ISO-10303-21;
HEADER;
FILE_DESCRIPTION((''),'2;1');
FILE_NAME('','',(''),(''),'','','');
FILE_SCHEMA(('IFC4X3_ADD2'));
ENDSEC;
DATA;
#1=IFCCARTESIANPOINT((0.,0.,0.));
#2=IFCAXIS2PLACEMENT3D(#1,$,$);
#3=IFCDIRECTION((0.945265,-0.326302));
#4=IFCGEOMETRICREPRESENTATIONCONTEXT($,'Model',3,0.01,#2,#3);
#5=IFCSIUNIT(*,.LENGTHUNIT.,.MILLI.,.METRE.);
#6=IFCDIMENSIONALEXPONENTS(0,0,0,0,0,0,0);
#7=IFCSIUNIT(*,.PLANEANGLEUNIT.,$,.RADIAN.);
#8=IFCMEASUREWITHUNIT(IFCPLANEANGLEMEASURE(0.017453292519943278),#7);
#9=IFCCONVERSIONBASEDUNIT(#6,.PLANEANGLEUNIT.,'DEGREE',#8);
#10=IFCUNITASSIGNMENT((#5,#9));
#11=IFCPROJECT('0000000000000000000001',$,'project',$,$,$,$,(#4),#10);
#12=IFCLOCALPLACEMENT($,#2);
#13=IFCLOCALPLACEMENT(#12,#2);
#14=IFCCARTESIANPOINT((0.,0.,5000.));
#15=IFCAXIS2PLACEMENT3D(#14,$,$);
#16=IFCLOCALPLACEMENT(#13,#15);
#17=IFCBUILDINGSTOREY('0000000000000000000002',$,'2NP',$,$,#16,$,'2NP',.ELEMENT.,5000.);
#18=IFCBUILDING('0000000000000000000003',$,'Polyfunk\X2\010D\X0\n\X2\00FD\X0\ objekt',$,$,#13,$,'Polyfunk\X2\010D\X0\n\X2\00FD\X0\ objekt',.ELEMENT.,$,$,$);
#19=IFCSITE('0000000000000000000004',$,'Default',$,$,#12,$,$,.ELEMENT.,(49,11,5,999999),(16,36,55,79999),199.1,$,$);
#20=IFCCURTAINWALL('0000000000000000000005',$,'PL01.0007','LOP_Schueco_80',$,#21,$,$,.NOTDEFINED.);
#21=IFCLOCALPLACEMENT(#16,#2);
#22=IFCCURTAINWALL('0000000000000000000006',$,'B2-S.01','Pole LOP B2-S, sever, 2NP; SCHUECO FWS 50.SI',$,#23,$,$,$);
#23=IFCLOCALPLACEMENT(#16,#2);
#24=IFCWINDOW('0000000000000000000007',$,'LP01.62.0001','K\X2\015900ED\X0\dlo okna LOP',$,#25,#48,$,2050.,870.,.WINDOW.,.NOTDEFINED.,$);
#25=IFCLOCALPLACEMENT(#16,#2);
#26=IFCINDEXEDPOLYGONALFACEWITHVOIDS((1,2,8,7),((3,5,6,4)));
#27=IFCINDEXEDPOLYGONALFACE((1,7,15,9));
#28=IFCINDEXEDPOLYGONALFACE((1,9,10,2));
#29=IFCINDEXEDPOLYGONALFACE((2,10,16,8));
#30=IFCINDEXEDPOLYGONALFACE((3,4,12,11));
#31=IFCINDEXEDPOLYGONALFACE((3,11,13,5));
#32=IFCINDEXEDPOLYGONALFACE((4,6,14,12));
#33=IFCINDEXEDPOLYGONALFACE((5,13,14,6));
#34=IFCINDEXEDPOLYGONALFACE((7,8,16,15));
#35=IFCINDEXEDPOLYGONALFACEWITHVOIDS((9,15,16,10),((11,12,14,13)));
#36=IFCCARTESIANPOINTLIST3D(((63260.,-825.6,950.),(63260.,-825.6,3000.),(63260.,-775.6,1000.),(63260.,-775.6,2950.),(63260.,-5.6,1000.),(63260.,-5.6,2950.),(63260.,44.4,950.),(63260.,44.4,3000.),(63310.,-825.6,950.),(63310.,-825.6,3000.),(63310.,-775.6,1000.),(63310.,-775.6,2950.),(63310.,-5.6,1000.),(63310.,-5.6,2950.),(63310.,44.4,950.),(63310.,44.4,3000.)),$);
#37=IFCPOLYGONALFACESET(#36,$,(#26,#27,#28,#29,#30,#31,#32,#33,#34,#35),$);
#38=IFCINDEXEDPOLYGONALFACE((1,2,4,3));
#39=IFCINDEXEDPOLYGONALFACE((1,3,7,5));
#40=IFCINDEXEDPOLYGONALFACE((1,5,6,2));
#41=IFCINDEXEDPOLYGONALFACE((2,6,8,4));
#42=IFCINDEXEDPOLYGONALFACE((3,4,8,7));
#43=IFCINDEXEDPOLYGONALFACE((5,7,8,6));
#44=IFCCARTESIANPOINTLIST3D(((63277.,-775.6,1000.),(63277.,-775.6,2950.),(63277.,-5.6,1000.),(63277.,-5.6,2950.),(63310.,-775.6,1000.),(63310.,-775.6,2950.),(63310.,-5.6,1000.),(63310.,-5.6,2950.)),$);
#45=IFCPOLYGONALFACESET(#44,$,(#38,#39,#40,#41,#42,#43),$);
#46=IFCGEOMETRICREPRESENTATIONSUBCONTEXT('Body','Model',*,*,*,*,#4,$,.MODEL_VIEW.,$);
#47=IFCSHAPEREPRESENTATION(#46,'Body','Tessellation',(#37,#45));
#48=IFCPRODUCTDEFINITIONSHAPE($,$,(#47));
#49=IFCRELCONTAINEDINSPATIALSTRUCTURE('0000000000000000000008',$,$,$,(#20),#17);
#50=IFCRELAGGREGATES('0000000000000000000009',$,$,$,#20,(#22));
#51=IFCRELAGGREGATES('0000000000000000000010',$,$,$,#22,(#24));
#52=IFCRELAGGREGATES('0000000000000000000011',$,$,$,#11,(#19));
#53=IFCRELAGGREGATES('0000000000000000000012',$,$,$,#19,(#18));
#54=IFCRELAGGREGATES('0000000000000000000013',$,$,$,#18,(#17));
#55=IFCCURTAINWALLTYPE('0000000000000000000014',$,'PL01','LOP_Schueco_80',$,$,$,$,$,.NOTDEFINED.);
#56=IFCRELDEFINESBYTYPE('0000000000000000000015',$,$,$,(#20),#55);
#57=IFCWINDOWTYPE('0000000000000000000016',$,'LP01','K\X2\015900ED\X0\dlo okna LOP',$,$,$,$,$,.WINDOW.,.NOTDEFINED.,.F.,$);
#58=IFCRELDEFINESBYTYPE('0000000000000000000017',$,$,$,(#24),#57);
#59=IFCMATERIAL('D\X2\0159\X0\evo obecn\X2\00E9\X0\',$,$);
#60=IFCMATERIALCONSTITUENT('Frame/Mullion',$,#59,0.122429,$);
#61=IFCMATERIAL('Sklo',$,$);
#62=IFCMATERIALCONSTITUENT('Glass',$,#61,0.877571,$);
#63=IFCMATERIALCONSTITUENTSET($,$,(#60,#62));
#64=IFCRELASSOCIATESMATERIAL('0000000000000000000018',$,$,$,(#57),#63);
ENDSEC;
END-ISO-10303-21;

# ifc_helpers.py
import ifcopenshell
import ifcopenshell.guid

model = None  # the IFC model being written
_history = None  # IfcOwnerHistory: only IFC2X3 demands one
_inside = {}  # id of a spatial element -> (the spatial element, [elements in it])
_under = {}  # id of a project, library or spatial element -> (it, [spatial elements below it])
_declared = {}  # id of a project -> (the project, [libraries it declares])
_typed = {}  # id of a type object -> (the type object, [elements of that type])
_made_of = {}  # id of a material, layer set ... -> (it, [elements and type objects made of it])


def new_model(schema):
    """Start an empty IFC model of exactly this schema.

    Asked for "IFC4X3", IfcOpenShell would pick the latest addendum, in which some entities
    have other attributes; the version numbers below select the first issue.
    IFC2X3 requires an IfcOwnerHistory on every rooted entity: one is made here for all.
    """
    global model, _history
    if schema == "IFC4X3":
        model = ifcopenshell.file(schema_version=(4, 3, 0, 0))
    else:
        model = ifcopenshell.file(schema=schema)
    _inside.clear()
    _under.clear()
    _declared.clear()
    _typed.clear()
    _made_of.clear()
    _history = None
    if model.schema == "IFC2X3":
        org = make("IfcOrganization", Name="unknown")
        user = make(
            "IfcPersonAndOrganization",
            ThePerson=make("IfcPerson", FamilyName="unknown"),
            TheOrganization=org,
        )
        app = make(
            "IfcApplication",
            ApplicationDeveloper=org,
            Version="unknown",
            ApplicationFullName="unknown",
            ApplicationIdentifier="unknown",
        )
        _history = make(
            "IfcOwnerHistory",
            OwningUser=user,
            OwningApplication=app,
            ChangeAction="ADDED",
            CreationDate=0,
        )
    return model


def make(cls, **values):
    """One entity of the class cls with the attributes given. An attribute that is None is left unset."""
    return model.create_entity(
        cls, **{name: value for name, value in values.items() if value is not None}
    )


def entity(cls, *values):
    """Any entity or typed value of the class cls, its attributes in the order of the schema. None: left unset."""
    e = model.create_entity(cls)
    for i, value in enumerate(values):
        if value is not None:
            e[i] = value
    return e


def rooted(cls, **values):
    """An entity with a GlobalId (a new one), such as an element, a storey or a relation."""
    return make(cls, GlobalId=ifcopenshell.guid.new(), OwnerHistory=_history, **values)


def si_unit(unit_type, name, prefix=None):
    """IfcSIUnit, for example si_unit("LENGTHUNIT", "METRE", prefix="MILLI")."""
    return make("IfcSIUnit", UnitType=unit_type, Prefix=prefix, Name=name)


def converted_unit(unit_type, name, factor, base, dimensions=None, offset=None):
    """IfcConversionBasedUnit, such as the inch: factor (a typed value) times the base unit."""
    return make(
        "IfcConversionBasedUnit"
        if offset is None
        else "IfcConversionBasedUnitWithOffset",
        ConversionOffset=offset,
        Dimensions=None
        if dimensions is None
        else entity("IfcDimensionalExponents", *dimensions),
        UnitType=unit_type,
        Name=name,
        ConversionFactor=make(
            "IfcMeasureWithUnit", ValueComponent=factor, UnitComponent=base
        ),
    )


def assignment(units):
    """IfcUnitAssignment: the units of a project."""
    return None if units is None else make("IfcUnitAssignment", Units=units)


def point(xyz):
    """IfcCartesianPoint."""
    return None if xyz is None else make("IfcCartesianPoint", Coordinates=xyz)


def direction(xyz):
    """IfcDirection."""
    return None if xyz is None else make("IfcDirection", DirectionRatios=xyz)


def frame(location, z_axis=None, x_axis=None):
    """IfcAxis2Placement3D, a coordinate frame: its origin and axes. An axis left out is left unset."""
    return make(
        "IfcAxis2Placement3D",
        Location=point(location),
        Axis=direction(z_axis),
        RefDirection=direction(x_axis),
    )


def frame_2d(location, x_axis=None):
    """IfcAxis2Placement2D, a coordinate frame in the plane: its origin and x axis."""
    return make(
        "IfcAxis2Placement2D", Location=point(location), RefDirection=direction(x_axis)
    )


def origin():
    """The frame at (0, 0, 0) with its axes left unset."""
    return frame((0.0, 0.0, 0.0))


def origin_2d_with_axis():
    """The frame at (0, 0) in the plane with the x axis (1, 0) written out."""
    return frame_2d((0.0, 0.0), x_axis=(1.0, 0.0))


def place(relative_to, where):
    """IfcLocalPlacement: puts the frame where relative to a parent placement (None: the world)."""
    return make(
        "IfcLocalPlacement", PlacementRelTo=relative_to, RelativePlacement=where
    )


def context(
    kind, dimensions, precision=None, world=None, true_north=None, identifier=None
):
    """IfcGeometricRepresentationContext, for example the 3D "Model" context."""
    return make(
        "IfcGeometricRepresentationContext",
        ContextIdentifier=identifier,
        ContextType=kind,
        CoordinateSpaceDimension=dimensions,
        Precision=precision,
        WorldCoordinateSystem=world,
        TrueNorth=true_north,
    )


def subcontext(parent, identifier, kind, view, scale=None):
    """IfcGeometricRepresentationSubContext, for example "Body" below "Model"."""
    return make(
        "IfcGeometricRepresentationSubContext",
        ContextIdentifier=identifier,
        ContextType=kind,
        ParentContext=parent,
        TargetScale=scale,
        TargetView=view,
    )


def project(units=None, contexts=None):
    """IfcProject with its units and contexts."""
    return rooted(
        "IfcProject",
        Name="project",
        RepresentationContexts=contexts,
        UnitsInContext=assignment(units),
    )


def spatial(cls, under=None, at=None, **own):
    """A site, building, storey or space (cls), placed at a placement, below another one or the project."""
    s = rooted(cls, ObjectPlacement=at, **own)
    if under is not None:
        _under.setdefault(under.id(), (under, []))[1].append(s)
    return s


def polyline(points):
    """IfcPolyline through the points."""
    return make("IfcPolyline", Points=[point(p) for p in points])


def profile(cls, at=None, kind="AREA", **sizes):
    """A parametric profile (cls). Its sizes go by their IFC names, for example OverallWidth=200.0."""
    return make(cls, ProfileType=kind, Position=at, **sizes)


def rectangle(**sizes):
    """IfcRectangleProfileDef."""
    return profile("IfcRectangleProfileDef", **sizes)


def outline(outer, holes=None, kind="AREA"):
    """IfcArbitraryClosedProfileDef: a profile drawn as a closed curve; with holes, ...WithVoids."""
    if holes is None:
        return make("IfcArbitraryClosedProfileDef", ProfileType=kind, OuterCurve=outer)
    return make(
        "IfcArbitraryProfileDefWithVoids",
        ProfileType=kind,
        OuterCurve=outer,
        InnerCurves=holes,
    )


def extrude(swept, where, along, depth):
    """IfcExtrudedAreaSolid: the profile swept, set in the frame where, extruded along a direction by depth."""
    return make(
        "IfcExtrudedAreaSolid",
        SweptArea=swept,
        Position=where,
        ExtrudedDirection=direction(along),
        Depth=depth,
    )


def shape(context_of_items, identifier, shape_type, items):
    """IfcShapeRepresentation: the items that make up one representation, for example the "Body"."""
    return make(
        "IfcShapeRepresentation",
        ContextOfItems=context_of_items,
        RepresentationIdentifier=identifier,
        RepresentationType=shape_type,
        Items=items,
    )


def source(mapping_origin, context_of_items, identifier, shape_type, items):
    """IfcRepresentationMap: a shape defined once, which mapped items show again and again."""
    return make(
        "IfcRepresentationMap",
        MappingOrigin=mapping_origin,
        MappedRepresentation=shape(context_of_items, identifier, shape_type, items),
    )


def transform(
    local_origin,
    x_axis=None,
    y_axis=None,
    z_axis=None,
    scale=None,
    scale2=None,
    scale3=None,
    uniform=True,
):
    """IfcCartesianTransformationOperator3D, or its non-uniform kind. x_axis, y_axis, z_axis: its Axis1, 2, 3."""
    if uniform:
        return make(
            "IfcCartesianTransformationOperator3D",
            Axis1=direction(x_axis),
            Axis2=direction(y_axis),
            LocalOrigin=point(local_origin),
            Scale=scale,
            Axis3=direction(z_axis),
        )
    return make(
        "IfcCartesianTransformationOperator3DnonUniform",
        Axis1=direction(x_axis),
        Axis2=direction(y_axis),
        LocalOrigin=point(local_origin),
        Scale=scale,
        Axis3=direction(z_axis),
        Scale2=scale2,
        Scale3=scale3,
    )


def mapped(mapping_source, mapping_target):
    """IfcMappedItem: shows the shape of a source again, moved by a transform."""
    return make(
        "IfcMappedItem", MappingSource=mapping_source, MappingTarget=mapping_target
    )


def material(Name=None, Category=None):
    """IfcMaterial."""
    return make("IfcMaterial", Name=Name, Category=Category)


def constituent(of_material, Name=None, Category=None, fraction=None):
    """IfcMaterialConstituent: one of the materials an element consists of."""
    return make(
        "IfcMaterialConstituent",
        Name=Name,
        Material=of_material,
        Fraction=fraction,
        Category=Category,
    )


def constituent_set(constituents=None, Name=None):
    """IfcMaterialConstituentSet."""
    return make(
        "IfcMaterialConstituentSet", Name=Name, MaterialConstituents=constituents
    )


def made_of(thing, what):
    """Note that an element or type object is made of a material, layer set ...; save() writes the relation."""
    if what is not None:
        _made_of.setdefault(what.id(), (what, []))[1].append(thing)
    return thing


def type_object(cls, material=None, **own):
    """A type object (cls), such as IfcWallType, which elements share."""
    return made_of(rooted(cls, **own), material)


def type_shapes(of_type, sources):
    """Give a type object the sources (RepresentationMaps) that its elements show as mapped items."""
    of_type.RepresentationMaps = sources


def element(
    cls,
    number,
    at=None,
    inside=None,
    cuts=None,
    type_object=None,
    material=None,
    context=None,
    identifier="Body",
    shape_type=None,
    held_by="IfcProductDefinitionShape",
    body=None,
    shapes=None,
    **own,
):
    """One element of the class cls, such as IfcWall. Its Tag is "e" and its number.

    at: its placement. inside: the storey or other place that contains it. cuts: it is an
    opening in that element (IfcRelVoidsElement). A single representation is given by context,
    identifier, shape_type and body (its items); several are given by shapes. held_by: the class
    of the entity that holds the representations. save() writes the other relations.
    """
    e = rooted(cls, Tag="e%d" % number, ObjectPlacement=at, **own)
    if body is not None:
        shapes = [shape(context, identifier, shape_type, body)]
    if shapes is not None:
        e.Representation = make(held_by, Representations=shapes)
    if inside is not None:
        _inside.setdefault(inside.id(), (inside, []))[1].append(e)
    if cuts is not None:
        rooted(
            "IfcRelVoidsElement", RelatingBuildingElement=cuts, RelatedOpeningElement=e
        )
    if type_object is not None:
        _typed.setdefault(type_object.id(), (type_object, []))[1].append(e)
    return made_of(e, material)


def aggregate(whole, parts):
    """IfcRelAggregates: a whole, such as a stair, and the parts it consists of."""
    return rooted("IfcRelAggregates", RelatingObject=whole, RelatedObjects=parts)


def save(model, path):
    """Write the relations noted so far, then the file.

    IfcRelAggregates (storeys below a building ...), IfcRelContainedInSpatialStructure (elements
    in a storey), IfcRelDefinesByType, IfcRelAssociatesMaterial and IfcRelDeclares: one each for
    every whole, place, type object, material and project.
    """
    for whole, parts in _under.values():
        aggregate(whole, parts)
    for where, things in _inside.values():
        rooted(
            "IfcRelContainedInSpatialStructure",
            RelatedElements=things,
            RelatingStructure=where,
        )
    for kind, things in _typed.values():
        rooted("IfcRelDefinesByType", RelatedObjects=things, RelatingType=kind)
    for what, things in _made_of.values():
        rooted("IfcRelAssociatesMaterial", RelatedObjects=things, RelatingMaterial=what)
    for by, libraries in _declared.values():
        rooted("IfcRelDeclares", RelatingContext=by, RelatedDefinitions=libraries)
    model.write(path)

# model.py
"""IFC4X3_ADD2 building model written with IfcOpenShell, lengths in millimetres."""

from ifc_helpers import new_model, entity, si_unit, converted_unit, direction, frame, origin, origin_2d_with_axis, place, context, subcontext, project, spatial, polyline, rectangle, outline, extrude, source, transform, mapped, material, constituent, constituent_set, type_object, type_shapes, element, aggregate, save


model = new_model("IFC4X3_ADD2")

# Units and contexts
model_context = context("Model", 3, precision=0.01, world=origin(), true_north=direction((0.945265, -0.326302)))
body_context = subcontext(model_context, "Body", "Model", "MODEL_VIEW")
ifc_project = project(units=[si_unit("LENGTHUNIT", "METRE", prefix="MILLI"), converted_unit("PLANEANGLEUNIT", "DEGREE", entity("IfcPlaneAngleMeasure", 0.017453292519943278), si_unit("PLANEANGLEUNIT", "RADIAN"), dimensions=[0, 0, 0, 0, 0, 0, 0])], contexts=[model_context])

# Site, building, storey
site_placement = place(None, origin())
site = spatial("IfcSite", under=ifc_project, at=site_placement, Name="Default", CompositionType="ELEMENT", RefLatitude=(49, 11, 5, 999999), RefLongitude=(16, 36, 55, 79999), RefElevation=199.1)
building_placement = place(site_placement, origin())
building = spatial("IfcBuilding", under=site, at=building_placement, Name="Polyfunkčný objekt", LongName="Polyfunkčný objekt", CompositionType="ELEMENT")
storey_placement = place(building_placement, frame((0.0, 0.0, 5000.0)))
storey = spatial("IfcBuildingStorey", under=building, at=storey_placement, Name="2NP", LongName="2NP", CompositionType="ELEMENT", Elevation=5000.0)

# Curtain walls, window
curtain_wall_type = type_object("IfcCurtainWallType", Name="PL01", Description="LOP_Schueco_80", PredefinedType="NOTDEFINED")
curtain_wall_1_placement = place(storey_placement, frame((0.0, 0.0, -5000.0)))
curtain_wall_1 = element("IfcCurtainWall", 1, at=curtain_wall_1_placement, inside=storey, type_object=curtain_wall_type, Name="PL01.0007", Description="LOP_Schueco_80", PredefinedType="NOTDEFINED")
curtain_wall_2 = element("IfcCurtainWall", 2, Name="B2-S.01", Description="Pole LOP B2-S, sever, 2NP; SCHUECO FWS 50.SI")
aggregate(curtain_wall_1, [curtain_wall_2])
ifc_material_1 = material(Name="Sklo")
ifc_material_2 = material(Name="Dřevo obecné")
ifc_constituent_1 = constituent(ifc_material_2, Name="Frame/Mullion", fraction=0.122429)
ifc_constituent_2 = constituent(ifc_material_1, Name="Glass", fraction=0.877571)
ifc_constituent_set = constituent_set(constituents=[ifc_constituent_1, ifc_constituent_2])
window_type = type_object("IfcWindowType", Name="LP01", Description="Křídlo okna LOP", ParameterTakesPrecedence=False, PartitioningType="NOTDEFINED", PredefinedType="WINDOW", material=ifc_constituent_set)
shared_shape_1 = source(origin(), body_context, "Body", "SweptSolid", [
    extrude(outline(polyline([(-1025.0, -435.0), (1025.0, -435.0), (1025.0, 435.0), (-1025.0, 435.0), (-1025.0, -435.0)]), holes=[polyline([(-975.0, -385.0), (-975.0, 385.0), (975.0, 385.0), (975.0, -385.0), (-975.0, -385.0)])]), frame((0.0, 0.0, 1025.0), z_axis=(0.0, 1.0, 0.0), x_axis=(0.0, 0.0, -1.0)), (0.0, 0.0, 1.0), 50.0),
    extrude(rectangle(XDim=33.0, YDim=770.0, at=origin_2d_with_axis()), frame((0.0, 33.5, 50.0), z_axis=(0.0, 0.0, 1.0), x_axis=(0.0, -1.0, 0.0)), (0.0, 0.0, 1.0), 1950.0),
])
type_shapes(window_type, [shared_shape_1])
window_placement = place(curtain_wall_1_placement, frame((63260.0, -390.6, 5950.0), z_axis=(0.0, 0.0, 1.0), x_axis=(0.0, -1.0, 0.0)))
window = element("IfcWindow", 3, at=window_placement, type_object=window_type, Name="LP01.62.0001", Description="Křídlo okna LOP", OverallHeight=2050.0, OverallWidth=870.0, PartitioningType="NOTDEFINED", PredefinedType="WINDOW", context=body_context, shape_type="MappedRepresentation", body=[
    mapped(shared_shape_1, transform((0.0, 0.0, 0.0), scale=1.0)),
])
aggregate(curtain_wall_2, [window])

save(model, "model.ifc")
